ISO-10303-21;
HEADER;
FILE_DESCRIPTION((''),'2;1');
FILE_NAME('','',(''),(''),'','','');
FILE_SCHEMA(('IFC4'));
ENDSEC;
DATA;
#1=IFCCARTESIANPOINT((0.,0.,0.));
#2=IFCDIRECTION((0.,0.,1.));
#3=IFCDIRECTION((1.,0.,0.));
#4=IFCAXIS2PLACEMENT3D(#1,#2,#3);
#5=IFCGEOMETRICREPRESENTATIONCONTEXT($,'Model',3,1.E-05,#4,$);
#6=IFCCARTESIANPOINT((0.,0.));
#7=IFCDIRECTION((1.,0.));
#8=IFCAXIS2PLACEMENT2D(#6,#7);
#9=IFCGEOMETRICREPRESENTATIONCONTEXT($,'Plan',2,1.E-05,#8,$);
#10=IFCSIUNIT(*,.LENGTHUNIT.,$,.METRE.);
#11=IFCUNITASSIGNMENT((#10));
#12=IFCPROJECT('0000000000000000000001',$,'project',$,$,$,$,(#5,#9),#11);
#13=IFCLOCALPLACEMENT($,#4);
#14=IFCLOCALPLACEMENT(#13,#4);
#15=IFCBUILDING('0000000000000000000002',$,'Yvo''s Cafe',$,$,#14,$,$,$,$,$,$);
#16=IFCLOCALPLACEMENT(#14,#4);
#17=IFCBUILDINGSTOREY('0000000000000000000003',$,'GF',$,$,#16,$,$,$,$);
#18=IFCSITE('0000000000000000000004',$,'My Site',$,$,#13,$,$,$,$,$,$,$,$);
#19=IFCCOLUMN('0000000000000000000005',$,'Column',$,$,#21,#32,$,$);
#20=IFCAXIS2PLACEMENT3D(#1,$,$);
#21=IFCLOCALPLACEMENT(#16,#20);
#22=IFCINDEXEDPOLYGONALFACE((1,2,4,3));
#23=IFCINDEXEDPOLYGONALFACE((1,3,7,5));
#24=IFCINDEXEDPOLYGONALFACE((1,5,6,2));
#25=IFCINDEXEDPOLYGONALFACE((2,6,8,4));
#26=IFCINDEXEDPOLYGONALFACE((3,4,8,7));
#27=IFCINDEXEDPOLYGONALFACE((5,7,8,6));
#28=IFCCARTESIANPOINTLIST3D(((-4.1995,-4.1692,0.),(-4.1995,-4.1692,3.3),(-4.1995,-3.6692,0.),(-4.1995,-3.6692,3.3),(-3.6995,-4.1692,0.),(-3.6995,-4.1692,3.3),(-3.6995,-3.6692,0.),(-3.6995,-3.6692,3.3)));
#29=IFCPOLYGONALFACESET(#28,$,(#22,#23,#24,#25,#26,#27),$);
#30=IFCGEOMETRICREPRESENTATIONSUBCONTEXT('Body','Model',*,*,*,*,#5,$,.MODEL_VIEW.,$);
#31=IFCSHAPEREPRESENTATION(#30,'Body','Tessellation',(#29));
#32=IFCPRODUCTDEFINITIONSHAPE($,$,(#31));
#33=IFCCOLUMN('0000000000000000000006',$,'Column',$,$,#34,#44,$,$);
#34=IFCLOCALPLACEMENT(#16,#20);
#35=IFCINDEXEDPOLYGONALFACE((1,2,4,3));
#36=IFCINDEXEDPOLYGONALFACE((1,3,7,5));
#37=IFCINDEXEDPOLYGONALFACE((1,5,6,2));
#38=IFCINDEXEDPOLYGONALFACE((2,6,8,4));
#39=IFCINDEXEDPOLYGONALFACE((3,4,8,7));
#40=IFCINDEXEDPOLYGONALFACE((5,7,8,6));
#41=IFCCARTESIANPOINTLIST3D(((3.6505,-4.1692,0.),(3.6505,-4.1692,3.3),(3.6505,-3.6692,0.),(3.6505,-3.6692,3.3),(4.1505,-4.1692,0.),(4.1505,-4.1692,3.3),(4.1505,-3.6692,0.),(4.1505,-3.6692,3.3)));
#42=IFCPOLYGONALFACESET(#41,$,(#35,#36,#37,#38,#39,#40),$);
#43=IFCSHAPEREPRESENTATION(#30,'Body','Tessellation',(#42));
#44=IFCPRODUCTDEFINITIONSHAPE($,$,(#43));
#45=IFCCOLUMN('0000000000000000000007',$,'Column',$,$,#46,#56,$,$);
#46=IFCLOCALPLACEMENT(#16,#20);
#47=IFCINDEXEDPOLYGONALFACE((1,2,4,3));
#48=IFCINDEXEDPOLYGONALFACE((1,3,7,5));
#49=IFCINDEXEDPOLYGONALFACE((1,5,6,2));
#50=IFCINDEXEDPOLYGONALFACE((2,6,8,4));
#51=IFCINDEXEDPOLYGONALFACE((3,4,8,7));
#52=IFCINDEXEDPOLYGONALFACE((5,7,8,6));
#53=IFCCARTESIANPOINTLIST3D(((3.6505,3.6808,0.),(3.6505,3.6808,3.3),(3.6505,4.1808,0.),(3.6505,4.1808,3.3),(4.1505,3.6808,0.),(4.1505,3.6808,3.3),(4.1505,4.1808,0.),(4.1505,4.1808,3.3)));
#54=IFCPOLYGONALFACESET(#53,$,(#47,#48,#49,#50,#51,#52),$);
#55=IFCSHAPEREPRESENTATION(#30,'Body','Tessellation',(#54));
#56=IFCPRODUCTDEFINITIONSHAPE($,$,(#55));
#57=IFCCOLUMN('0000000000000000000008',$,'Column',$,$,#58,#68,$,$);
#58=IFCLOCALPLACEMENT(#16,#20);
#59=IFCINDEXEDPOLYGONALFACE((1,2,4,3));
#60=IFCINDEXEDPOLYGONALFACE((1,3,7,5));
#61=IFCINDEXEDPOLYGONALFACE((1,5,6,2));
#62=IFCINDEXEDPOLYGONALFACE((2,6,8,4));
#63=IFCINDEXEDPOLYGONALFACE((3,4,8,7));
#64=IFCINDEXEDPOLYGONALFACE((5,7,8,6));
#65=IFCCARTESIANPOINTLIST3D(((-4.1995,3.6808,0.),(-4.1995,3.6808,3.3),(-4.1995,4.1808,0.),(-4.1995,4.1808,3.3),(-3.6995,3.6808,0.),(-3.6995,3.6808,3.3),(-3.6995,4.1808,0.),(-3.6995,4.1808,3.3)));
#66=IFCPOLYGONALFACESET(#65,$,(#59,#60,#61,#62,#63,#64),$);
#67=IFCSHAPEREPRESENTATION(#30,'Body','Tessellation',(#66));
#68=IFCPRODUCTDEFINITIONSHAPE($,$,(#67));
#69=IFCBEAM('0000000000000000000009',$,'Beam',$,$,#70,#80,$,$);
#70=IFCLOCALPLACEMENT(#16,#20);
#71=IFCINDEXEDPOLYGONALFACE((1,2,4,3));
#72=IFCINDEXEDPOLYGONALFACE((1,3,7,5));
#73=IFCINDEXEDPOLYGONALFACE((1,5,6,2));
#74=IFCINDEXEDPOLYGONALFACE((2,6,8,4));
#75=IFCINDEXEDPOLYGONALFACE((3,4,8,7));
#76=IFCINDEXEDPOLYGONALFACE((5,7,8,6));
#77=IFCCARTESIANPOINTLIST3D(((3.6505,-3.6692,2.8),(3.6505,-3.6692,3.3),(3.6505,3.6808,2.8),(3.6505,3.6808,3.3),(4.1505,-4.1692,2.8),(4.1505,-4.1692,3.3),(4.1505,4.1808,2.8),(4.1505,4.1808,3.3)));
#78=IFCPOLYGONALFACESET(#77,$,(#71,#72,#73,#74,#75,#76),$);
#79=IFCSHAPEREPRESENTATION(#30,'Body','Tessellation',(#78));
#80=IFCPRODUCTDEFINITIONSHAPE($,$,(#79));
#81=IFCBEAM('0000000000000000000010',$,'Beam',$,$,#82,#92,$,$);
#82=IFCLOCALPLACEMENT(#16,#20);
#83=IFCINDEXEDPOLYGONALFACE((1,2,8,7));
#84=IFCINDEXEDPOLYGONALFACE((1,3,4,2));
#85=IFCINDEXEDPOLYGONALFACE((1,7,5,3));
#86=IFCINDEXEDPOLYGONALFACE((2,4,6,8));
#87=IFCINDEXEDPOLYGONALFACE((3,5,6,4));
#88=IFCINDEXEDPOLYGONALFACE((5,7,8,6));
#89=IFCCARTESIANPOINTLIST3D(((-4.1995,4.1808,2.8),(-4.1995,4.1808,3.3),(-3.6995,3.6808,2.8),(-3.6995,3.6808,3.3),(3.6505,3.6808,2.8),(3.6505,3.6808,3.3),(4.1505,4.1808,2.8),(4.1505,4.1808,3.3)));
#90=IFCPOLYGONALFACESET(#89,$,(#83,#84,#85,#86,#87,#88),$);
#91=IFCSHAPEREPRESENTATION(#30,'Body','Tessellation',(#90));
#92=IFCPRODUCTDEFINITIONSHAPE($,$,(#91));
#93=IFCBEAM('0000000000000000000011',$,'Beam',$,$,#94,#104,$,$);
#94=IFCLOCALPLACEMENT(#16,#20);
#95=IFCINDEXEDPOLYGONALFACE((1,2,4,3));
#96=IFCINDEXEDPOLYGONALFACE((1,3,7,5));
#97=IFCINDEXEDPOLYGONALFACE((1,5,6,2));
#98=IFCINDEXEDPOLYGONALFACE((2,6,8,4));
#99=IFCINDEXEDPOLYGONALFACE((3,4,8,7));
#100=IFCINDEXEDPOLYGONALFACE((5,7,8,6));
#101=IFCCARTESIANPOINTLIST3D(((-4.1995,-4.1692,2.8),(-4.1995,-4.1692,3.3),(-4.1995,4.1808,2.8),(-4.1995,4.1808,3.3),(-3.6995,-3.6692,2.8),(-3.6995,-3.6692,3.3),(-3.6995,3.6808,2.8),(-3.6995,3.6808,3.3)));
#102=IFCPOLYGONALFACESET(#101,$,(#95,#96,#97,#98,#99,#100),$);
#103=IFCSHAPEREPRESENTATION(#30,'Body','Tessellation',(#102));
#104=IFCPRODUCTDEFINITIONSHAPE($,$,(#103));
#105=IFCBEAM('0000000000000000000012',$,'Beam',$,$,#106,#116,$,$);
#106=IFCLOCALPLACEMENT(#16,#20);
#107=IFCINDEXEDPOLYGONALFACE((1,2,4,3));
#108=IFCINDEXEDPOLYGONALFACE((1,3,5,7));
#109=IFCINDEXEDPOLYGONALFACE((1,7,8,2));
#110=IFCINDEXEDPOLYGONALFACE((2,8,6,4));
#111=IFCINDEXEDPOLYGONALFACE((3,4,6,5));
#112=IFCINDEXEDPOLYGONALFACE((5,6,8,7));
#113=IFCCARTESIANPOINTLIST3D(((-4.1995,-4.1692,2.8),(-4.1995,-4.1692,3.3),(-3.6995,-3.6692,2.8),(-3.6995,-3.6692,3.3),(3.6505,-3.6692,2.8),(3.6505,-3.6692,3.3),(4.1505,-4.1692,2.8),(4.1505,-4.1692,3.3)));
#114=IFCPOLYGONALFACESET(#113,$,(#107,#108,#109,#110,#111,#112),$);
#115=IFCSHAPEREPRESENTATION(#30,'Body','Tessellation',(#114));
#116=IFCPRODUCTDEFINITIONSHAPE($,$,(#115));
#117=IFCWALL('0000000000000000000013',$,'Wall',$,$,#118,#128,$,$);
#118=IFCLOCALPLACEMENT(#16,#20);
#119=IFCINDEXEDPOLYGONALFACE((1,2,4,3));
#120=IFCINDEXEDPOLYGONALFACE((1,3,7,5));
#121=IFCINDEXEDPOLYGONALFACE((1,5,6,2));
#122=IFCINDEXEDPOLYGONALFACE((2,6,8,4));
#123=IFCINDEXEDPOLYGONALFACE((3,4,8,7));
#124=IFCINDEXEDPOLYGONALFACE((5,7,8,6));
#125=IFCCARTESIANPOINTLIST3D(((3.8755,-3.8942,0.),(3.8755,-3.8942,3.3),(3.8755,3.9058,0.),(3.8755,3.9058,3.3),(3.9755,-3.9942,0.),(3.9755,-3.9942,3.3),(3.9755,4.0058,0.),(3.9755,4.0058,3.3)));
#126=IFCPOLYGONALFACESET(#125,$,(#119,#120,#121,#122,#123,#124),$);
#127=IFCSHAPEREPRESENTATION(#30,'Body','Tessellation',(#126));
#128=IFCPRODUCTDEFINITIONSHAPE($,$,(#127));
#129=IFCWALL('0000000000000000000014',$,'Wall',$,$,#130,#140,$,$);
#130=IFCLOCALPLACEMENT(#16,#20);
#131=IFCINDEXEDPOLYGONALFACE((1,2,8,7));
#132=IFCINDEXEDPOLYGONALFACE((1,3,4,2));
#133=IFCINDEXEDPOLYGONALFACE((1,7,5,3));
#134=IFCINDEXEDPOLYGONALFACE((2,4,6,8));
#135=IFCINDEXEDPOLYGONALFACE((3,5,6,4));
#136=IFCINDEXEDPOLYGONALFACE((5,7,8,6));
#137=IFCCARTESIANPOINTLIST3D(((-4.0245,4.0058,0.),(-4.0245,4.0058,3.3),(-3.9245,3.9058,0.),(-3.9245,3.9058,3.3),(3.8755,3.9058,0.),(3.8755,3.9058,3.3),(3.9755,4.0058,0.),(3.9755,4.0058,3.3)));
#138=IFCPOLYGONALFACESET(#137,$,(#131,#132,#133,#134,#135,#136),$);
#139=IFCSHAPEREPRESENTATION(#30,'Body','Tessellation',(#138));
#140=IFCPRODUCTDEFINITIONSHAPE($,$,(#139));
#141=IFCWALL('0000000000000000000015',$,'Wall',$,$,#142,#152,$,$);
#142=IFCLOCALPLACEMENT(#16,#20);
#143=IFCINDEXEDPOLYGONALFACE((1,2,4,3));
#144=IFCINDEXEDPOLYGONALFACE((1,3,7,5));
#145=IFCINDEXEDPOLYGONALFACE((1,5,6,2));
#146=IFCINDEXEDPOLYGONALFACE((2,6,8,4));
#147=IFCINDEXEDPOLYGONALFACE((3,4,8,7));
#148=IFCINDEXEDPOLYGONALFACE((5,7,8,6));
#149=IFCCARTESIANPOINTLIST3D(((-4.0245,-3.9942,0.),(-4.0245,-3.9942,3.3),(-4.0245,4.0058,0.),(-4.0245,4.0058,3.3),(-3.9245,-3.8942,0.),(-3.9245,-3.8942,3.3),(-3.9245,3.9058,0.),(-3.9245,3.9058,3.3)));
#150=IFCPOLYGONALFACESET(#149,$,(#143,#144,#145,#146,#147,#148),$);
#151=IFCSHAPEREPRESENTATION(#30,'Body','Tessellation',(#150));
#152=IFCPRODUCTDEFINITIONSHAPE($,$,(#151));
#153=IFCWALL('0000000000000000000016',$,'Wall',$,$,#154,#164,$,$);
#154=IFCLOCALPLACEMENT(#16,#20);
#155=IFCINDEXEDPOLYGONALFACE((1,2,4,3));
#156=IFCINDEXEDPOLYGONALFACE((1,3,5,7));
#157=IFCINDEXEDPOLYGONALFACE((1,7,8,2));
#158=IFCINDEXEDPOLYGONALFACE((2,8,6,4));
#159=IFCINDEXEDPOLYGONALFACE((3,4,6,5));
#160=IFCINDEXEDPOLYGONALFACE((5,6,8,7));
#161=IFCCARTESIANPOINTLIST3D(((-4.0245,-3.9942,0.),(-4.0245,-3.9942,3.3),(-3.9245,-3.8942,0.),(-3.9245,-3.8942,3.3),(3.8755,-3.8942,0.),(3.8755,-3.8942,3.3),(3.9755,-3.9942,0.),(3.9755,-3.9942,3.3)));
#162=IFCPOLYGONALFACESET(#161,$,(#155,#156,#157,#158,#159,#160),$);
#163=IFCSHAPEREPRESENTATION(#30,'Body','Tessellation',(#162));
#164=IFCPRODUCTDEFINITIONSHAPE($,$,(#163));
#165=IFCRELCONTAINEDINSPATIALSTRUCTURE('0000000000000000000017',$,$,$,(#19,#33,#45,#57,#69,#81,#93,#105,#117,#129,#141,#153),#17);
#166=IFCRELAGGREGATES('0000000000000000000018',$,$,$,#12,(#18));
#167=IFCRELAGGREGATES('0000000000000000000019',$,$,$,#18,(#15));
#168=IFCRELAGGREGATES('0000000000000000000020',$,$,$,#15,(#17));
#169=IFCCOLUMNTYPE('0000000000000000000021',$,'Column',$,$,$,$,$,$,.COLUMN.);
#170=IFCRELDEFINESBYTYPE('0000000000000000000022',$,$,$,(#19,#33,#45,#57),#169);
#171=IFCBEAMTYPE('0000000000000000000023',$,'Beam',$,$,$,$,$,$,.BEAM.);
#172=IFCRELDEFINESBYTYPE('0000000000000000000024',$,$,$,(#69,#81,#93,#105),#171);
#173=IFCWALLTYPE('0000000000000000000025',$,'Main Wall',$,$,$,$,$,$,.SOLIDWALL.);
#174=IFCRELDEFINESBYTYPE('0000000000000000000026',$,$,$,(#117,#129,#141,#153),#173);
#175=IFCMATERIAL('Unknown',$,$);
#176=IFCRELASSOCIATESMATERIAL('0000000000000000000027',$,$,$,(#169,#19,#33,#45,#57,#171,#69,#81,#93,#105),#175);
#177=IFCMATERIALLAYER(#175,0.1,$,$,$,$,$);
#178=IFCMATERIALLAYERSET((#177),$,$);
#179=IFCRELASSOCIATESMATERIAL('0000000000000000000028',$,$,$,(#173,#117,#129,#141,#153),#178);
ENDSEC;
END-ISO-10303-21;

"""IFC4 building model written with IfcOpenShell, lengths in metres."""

from ifc_helpers import new_model, si_unit, frame, origin_with_axes, origin_2d_with_axis, place, context, subcontext, project, spatial, line, indexed_curve, rectangle, outline, extrude, clip, halfspace, material, layer, layer_set, layer_usage, material_profile, profile_set, profile_usage, type_object, element, save


model = new_model("IFC4")

# Units and contexts
model_context = context("Model", 3, precision=1e-05, world=origin_with_axes())
plan_context = context("Plan", 2, precision=1e-05, world=origin_2d_with_axis())
body_context_1 = subcontext(model_context, "Body", "Model", "MODEL_VIEW")
ifc_project = project(units=[si_unit("LENGTHUNIT", "METRE")], contexts=[model_context, plan_context])

# Site, building, storey
site_placement = place(None, origin_with_axes())
site = spatial("IfcSite", under=ifc_project, at=site_placement, Name="My Site")
building_placement = place(site_placement, origin_with_axes())
building = spatial("IfcBuilding", under=site, at=building_placement, Name="Yvo's Cafe")
storey_placement = place(building_placement, origin_with_axes())
storey = spatial("IfcBuildingStorey", under=building, at=storey_placement, Name="GF")

# Columns
ifc_material = material(Name="Unknown")
ifc_material_profile_1 = material_profile(ifc_material, rectangle(XDim=0.5, YDim=0.5))
ifc_profile_set_1 = profile_set([ifc_material_profile_1])
ifc_profile_usage_1 = profile_usage(ifc_profile_set_1, cardinal=5)
column_type = type_object("IfcColumnType", Name="Column", PredefinedType="COLUMN", material=ifc_profile_set_1)
column_1_placement = place(storey_placement, frame((-3.9495, -3.9192, 0.0), z_axis=(0.0, 0.0, 1.0), x_axis=(1.0, 0.0, 0.0)))
element("IfcColumn", 1, at=column_1_placement, inside=storey, type_object=column_type, material=ifc_profile_usage_1, Name="Column", context=body_context_1, shape_type="SweptSolid", body=[
    extrude(rectangle(XDim=0.5, YDim=0.5), origin_with_axes(), (0.0, 0.0, 1.0), 3.3),
])
ifc_profile_usage_2 = profile_usage(ifc_profile_set_1, cardinal=5)
column_2_placement = place(storey_placement, frame((3.9005, -3.9192, 0.0), z_axis=(0.0, 0.0, 1.0), x_axis=(1.0, 0.0, 0.0)))
element("IfcColumn", 2, at=column_2_placement, inside=storey, type_object=column_type, material=ifc_profile_usage_2, Name="Column", context=body_context_1, shape_type="SweptSolid", body=[
    extrude(rectangle(XDim=0.5, YDim=0.5), origin_with_axes(), (0.0, 0.0, 1.0), 3.3),
])
ifc_profile_usage_3 = profile_usage(ifc_profile_set_1, cardinal=5)
column_3_placement = place(storey_placement, frame((3.9005, 3.9308, 0.0), z_axis=(0.0, 0.0, 1.0), x_axis=(1.0, 0.0, 0.0)))
element("IfcColumn", 3, at=column_3_placement, inside=storey, type_object=column_type, material=ifc_profile_usage_3, Name="Column", context=body_context_1, shape_type="SweptSolid", body=[
    extrude(rectangle(XDim=0.5, YDim=0.5), origin_with_axes(), (0.0, 0.0, 1.0), 3.3),
])
ifc_profile_usage_4 = profile_usage(ifc_profile_set_1, cardinal=5)
column_4_placement = place(storey_placement, frame((-3.9495, 3.9308, 0.0), z_axis=(0.0, 0.0, 1.0), x_axis=(1.0, 0.0, 0.0)))
element("IfcColumn", 4, at=column_4_placement, inside=storey, type_object=column_type, material=ifc_profile_usage_4, Name="Column", context=body_context_1, shape_type="SweptSolid", body=[
    extrude(rectangle(XDim=0.5, YDim=0.5), origin_with_axes(), (0.0, 0.0, 1.0), 3.3),
])

# Beams
ifc_material_profile_2 = material_profile(ifc_material, rectangle(XDim=0.5, YDim=0.5))
ifc_profile_set_2 = profile_set([ifc_material_profile_2])
ifc_profile_usage_5 = profile_usage(ifc_profile_set_2, cardinal=5)
beam_type = type_object("IfcBeamType", Name="Beam", PredefinedType="BEAM", material=ifc_profile_set_2)
beam_1_placement = place(storey_placement, frame((3.9005, -4.1692, 3.05), z_axis=(0.0, 1.0, 0.0), x_axis=(-1.0, 0.0, 0.0)))
element("IfcBeam", 5, at=beam_1_placement, inside=storey, type_object=beam_type, material=ifc_profile_usage_5, Name="Beam", context=body_context_1, shape_type="Clipping", body=[
    clip(clip(extrude(rectangle(XDim=0.5, YDim=0.5), origin_with_axes(), (0.0, 0.0, 1.0), 8.35), halfspace(frame((-0.25, -3.0, 8.35), z_axis=(0.707107, 0.0, 0.707106), x_axis=(0.0, -1.0, 0.0)), False)), halfspace(frame((-0.25, -3.0, 0.0), z_axis=(0.707107, 0.0, -0.707106), x_axis=(0.0, -1.0, 0.0)), False)),
])
ifc_profile_usage_6 = profile_usage(ifc_profile_set_2, cardinal=5)
beam_2_placement = place(storey_placement, frame((4.1505, 3.9308, 3.05), z_axis=(-1.0, -0.000001, 0.0), x_axis=(0.000001, -1.0, 0.0)))
element("IfcBeam", 6, at=beam_2_placement, inside=storey, type_object=beam_type, material=ifc_profile_usage_6, Name="Beam", context=body_context_1, shape_type="Clipping", body=[
    clip(clip(extrude(rectangle(XDim=0.5, YDim=0.5), origin_with_axes(), (0.0, 0.0, 1.0), 8.35), halfspace(frame((-0.25, -3.0, 8.35), z_axis=(0.707106, 0.0, 0.707107), x_axis=(0.0, -1.0, 0.0)), False)), halfspace(frame((-0.25, -3.0, 0.0), z_axis=(0.707107, 0.0, -0.707107), x_axis=(0.0, -1.0, 0.0)), False)),
])
ifc_profile_usage_7 = profile_usage(ifc_profile_set_2, cardinal=5)
beam_3_placement = place(storey_placement, frame((-3.9495, 4.1808, 3.05), z_axis=(0.0, -1.0, 0.0), x_axis=(1.0, 0.0, 0.0)))
element("IfcBeam", 7, at=beam_3_placement, inside=storey, type_object=beam_type, material=ifc_profile_usage_7, Name="Beam", context=body_context_1, shape_type="Clipping", body=[
    clip(clip(extrude(rectangle(XDim=0.5, YDim=0.5), origin_with_axes(), (0.0, 0.0, 1.0), 8.35), halfspace(frame((-0.25, -3.0, 8.35), z_axis=(0.707107, 0.0, 0.707107), x_axis=(0.0, -1.0, 0.0)), False)), halfspace(frame((-0.25, -3.0, 0.0), z_axis=(0.707107, 0.0, -0.707107), x_axis=(0.0, -1.0, 0.0)), False)),
])
ifc_profile_usage_8 = profile_usage(ifc_profile_set_2, cardinal=5)
beam_4_placement = place(storey_placement, frame((-4.1995, -3.9192, 3.05), z_axis=(1.0, 0.0, 0.0), x_axis=(0.0, 1.0, 0.0)))
element("IfcBeam", 8, at=beam_4_placement, inside=storey, type_object=beam_type, material=ifc_profile_usage_8, Name="Beam", context=body_context_1, shape_type="Clipping", body=[
    clip(clip(extrude(rectangle(XDim=0.5, YDim=0.5), origin_with_axes(), (0.0, 0.0, 1.0), 8.35), halfspace(frame((-0.25, -3.0, 8.35), z_axis=(0.707106, 0.0, 0.707107), x_axis=(0.0, -1.0, 0.0)), False)), halfspace(frame((-0.25, -3.0, 0.0), z_axis=(0.707106, 0.0, -0.707107), x_axis=(0.0, -1.0, 0.0)), False)),
])

# Walls
ifc_layer_1 = layer(ifc_material, 0.1)
ifc_layer_set_1 = layer_set([ifc_layer_1])
ifc_layer_usage_1 = layer_usage(ifc_layer_set_1, "AXIS2", "POSITIVE", 0.0)
wall_type = type_object("IfcWallType", Name="Main Wall", PredefinedType="SOLIDWALL", material=ifc_layer_set_1)
wall_1_placement = place(storey_placement, frame((3.9755, -3.9942, 0.0), z_axis=(0.0, 0.0, 1.0), x_axis=(0.0, 1.0, 0.0)))
element("IfcWall", 9, at=wall_1_placement, inside=storey, type_object=wall_type, material=ifc_layer_usage_1, Name="Wall", context=body_context_1, shape_type="SweptSolid", body=[
    extrude(outline(indexed_curve([(0.0, 0.0), (0.1, 0.1), (7.9, 0.1), (8.0, 0.0)], segments=[line(1, 2, 3, 4, 1)])), origin_with_axes(), (0.0, 0.0, 1.0), 3.3),
])
ifc_layer_usage_2 = layer_usage(ifc_layer_set_1, "AXIS2", "POSITIVE", 0.0)
wall_2_placement = place(storey_placement, frame((3.9755, 4.0058, 0.0), z_axis=(0.0, 0.0, 1.0), x_axis=(-1.0, 0.0, 0.0)))
element("IfcWall", 10, at=wall_2_placement, inside=storey, type_object=wall_type, material=ifc_layer_usage_2, Name="Wall", context=body_context_1, shape_type="SweptSolid", body=[
    extrude(outline(indexed_curve([(0.0, 0.0), (0.1, 0.1), (7.9, 0.1), (8.0, 0.0)], segments=[line(1, 2, 3, 4, 1)])), origin_with_axes(), (0.0, 0.0, 1.0), 3.3),
])
ifc_layer_usage_3 = layer_usage(ifc_layer_set_1, "AXIS2", "POSITIVE", 0.0)
wall_3_placement = place(storey_placement, frame((-4.0245, 4.0058, 0.0), z_axis=(0.0, 0.0, 1.0), x_axis=(0.0, -1.0, 0.0)))
element("IfcWall", 11, at=wall_3_placement, inside=storey, type_object=wall_type, material=ifc_layer_usage_3, Name="Wall", context=body_context_1, shape_type="SweptSolid", body=[
    extrude(outline(indexed_curve([(0.0, 0.0), (0.1, 0.1), (7.9, 0.1), (8.0, 0.0)], segments=[line(1, 2, 3, 4, 1)])), origin_with_axes(), (0.0, 0.0, 1.0), 3.3),
])
ifc_layer_usage_4 = layer_usage(ifc_layer_set_1, "AXIS2", "POSITIVE", 0.0)
wall_4_placement = place(storey_placement, frame((-4.0245, -3.9942, 0.0), z_axis=(0.0, 0.0, 1.0), x_axis=(1.0, 0.0, 0.0)))
element("IfcWall", 12, at=wall_4_placement, inside=storey, type_object=wall_type, material=ifc_layer_usage_4, Name="Wall", context=body_context_1, shape_type="SweptSolid", body=[
    extrude(outline(indexed_curve([(0.0, 0.0), (0.1, 0.1), (7.9, 0.1), (8.0, 0.0)], segments=[line(1, 2, 3, 4, 1)])), origin_with_axes(), (0.0, 0.0, 1.0), 3.3),
])

save(model, "model.ifc")
